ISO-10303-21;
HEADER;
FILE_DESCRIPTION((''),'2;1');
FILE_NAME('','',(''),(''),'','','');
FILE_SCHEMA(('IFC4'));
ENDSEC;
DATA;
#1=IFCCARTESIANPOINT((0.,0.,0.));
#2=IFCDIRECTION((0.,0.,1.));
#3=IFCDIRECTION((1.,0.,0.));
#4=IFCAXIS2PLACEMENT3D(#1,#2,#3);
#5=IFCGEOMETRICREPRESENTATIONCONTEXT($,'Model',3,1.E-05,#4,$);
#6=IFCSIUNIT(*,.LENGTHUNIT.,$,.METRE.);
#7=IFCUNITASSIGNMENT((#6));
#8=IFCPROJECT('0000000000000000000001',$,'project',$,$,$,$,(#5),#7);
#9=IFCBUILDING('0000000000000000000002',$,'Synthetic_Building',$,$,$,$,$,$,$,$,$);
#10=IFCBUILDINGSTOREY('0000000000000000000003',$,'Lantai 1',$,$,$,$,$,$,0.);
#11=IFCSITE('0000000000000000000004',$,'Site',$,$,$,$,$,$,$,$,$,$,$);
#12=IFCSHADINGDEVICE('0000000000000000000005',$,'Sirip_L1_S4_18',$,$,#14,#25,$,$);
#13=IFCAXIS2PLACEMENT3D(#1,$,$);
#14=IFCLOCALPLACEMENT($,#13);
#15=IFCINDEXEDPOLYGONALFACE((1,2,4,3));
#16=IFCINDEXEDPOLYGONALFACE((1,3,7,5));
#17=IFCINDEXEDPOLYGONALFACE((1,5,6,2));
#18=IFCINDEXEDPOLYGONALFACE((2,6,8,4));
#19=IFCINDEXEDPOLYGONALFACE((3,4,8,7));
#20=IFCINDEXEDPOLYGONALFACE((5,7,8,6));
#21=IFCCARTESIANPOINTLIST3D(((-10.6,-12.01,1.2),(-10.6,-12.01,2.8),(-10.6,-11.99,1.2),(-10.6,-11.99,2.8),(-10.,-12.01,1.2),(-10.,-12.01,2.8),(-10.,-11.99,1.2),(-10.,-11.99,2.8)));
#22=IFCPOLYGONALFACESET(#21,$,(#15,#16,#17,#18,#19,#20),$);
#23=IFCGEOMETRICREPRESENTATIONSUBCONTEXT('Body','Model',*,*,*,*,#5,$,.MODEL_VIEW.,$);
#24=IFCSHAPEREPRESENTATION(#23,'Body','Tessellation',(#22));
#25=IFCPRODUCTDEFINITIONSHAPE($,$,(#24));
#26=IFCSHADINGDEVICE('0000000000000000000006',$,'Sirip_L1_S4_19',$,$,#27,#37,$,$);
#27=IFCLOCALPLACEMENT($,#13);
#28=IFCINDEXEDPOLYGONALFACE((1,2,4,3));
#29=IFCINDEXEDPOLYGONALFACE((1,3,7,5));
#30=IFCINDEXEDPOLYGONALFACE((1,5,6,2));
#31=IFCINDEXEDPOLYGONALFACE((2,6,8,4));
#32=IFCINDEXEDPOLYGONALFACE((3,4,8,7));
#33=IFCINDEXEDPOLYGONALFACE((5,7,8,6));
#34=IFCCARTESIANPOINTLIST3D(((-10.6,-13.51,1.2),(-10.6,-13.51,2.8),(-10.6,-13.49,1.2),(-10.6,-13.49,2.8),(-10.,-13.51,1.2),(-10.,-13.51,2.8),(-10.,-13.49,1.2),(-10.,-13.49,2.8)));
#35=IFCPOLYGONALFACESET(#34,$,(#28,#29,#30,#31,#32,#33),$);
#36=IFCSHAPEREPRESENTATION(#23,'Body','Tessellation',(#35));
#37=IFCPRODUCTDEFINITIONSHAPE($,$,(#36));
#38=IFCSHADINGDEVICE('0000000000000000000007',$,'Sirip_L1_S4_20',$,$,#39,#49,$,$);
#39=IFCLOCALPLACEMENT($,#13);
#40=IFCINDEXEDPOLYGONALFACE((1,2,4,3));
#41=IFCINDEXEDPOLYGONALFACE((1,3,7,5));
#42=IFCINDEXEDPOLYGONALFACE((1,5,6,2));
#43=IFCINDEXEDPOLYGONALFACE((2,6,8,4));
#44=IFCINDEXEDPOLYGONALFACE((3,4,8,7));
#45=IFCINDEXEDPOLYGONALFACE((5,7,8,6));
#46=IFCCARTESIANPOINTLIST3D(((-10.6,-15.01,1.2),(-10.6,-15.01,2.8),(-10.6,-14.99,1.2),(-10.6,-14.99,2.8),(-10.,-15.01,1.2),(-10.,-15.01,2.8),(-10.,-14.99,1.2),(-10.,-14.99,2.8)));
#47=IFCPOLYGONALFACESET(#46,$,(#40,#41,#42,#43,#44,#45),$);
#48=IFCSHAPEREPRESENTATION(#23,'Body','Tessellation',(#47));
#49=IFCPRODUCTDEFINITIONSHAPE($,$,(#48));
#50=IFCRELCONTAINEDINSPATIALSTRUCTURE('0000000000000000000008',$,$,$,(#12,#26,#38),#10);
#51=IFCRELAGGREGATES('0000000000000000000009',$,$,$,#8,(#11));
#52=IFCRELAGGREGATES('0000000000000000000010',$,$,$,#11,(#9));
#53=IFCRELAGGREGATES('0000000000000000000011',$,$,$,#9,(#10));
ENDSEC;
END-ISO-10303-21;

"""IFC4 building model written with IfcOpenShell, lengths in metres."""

from ifc_helpers import new_model, si_unit, frame, origin_with_axes, place, context, subcontext, project, spatial, polyline, outline, extrude, element, save


model = new_model("IFC4")

# Units and contexts
model_context = context("Model", 3, precision=1e-05, world=origin_with_axes())
body_context = subcontext(model_context, "Body", "Model", "MODEL_VIEW")
ifc_project = project(units=[si_unit("LENGTHUNIT", "METRE")], contexts=[model_context])

# Site, building, storey
site = spatial("IfcSite", under=ifc_project, Name="Site")
building = spatial("IfcBuilding", under=site, Name="Synthetic_Building")
storey = spatial("IfcBuildingStorey", under=building, Name="Lantai 1", Elevation=0.0)

# Shading devices
shading_device_1_placement = place(None, origin_with_axes())
element("IfcShadingDevice", 1, at=shading_device_1_placement, inside=storey, Name="Sirip_L1_S4_18", context=body_context, shape_type="SweptSolid", body=[
    extrude(outline(polyline([(-10.0, -11.99), (-10.0, -12.01), (-10.6, -12.01), (-10.6, -11.99), (-10.0, -11.99)])), frame((0.0, 0.0, 1.2), z_axis=(0.0, 0.0, 1.0), x_axis=(1.0, 0.0, 0.0)), (0.0, 0.0, 1.0), 1.6),
])
shading_device_2_placement = place(None, origin_with_axes())
element("IfcShadingDevice", 2, at=shading_device_2_placement, inside=storey, Name="Sirip_L1_S4_19", context=body_context, shape_type="SweptSolid", body=[
    extrude(outline(polyline([(-10.0, -13.49), (-10.0, -13.51), (-10.6, -13.51), (-10.6, -13.49), (-10.0, -13.49)])), frame((0.0, 0.0, 1.2), z_axis=(0.0, 0.0, 1.0), x_axis=(1.0, 0.0, 0.0)), (0.0, 0.0, 1.0), 1.6),
])
shading_device_3_placement = place(None, origin_with_axes())
element("IfcShadingDevice", 3, at=shading_device_3_placement, inside=storey, Name="Sirip_L1_S4_20", context=body_context, shape_type="SweptSolid", body=[
    extrude(outline(polyline([(-10.0, -14.99), (-10.0, -15.01), (-10.6, -15.01), (-10.6, -14.99), (-10.0, -14.99)])), frame((0.0, 0.0, 1.2), z_axis=(0.0, 0.0, 1.0), x_axis=(1.0, 0.0, 0.0)), (0.0, 0.0, 1.0), 1.6),
])

save(model, "model.ifc")
